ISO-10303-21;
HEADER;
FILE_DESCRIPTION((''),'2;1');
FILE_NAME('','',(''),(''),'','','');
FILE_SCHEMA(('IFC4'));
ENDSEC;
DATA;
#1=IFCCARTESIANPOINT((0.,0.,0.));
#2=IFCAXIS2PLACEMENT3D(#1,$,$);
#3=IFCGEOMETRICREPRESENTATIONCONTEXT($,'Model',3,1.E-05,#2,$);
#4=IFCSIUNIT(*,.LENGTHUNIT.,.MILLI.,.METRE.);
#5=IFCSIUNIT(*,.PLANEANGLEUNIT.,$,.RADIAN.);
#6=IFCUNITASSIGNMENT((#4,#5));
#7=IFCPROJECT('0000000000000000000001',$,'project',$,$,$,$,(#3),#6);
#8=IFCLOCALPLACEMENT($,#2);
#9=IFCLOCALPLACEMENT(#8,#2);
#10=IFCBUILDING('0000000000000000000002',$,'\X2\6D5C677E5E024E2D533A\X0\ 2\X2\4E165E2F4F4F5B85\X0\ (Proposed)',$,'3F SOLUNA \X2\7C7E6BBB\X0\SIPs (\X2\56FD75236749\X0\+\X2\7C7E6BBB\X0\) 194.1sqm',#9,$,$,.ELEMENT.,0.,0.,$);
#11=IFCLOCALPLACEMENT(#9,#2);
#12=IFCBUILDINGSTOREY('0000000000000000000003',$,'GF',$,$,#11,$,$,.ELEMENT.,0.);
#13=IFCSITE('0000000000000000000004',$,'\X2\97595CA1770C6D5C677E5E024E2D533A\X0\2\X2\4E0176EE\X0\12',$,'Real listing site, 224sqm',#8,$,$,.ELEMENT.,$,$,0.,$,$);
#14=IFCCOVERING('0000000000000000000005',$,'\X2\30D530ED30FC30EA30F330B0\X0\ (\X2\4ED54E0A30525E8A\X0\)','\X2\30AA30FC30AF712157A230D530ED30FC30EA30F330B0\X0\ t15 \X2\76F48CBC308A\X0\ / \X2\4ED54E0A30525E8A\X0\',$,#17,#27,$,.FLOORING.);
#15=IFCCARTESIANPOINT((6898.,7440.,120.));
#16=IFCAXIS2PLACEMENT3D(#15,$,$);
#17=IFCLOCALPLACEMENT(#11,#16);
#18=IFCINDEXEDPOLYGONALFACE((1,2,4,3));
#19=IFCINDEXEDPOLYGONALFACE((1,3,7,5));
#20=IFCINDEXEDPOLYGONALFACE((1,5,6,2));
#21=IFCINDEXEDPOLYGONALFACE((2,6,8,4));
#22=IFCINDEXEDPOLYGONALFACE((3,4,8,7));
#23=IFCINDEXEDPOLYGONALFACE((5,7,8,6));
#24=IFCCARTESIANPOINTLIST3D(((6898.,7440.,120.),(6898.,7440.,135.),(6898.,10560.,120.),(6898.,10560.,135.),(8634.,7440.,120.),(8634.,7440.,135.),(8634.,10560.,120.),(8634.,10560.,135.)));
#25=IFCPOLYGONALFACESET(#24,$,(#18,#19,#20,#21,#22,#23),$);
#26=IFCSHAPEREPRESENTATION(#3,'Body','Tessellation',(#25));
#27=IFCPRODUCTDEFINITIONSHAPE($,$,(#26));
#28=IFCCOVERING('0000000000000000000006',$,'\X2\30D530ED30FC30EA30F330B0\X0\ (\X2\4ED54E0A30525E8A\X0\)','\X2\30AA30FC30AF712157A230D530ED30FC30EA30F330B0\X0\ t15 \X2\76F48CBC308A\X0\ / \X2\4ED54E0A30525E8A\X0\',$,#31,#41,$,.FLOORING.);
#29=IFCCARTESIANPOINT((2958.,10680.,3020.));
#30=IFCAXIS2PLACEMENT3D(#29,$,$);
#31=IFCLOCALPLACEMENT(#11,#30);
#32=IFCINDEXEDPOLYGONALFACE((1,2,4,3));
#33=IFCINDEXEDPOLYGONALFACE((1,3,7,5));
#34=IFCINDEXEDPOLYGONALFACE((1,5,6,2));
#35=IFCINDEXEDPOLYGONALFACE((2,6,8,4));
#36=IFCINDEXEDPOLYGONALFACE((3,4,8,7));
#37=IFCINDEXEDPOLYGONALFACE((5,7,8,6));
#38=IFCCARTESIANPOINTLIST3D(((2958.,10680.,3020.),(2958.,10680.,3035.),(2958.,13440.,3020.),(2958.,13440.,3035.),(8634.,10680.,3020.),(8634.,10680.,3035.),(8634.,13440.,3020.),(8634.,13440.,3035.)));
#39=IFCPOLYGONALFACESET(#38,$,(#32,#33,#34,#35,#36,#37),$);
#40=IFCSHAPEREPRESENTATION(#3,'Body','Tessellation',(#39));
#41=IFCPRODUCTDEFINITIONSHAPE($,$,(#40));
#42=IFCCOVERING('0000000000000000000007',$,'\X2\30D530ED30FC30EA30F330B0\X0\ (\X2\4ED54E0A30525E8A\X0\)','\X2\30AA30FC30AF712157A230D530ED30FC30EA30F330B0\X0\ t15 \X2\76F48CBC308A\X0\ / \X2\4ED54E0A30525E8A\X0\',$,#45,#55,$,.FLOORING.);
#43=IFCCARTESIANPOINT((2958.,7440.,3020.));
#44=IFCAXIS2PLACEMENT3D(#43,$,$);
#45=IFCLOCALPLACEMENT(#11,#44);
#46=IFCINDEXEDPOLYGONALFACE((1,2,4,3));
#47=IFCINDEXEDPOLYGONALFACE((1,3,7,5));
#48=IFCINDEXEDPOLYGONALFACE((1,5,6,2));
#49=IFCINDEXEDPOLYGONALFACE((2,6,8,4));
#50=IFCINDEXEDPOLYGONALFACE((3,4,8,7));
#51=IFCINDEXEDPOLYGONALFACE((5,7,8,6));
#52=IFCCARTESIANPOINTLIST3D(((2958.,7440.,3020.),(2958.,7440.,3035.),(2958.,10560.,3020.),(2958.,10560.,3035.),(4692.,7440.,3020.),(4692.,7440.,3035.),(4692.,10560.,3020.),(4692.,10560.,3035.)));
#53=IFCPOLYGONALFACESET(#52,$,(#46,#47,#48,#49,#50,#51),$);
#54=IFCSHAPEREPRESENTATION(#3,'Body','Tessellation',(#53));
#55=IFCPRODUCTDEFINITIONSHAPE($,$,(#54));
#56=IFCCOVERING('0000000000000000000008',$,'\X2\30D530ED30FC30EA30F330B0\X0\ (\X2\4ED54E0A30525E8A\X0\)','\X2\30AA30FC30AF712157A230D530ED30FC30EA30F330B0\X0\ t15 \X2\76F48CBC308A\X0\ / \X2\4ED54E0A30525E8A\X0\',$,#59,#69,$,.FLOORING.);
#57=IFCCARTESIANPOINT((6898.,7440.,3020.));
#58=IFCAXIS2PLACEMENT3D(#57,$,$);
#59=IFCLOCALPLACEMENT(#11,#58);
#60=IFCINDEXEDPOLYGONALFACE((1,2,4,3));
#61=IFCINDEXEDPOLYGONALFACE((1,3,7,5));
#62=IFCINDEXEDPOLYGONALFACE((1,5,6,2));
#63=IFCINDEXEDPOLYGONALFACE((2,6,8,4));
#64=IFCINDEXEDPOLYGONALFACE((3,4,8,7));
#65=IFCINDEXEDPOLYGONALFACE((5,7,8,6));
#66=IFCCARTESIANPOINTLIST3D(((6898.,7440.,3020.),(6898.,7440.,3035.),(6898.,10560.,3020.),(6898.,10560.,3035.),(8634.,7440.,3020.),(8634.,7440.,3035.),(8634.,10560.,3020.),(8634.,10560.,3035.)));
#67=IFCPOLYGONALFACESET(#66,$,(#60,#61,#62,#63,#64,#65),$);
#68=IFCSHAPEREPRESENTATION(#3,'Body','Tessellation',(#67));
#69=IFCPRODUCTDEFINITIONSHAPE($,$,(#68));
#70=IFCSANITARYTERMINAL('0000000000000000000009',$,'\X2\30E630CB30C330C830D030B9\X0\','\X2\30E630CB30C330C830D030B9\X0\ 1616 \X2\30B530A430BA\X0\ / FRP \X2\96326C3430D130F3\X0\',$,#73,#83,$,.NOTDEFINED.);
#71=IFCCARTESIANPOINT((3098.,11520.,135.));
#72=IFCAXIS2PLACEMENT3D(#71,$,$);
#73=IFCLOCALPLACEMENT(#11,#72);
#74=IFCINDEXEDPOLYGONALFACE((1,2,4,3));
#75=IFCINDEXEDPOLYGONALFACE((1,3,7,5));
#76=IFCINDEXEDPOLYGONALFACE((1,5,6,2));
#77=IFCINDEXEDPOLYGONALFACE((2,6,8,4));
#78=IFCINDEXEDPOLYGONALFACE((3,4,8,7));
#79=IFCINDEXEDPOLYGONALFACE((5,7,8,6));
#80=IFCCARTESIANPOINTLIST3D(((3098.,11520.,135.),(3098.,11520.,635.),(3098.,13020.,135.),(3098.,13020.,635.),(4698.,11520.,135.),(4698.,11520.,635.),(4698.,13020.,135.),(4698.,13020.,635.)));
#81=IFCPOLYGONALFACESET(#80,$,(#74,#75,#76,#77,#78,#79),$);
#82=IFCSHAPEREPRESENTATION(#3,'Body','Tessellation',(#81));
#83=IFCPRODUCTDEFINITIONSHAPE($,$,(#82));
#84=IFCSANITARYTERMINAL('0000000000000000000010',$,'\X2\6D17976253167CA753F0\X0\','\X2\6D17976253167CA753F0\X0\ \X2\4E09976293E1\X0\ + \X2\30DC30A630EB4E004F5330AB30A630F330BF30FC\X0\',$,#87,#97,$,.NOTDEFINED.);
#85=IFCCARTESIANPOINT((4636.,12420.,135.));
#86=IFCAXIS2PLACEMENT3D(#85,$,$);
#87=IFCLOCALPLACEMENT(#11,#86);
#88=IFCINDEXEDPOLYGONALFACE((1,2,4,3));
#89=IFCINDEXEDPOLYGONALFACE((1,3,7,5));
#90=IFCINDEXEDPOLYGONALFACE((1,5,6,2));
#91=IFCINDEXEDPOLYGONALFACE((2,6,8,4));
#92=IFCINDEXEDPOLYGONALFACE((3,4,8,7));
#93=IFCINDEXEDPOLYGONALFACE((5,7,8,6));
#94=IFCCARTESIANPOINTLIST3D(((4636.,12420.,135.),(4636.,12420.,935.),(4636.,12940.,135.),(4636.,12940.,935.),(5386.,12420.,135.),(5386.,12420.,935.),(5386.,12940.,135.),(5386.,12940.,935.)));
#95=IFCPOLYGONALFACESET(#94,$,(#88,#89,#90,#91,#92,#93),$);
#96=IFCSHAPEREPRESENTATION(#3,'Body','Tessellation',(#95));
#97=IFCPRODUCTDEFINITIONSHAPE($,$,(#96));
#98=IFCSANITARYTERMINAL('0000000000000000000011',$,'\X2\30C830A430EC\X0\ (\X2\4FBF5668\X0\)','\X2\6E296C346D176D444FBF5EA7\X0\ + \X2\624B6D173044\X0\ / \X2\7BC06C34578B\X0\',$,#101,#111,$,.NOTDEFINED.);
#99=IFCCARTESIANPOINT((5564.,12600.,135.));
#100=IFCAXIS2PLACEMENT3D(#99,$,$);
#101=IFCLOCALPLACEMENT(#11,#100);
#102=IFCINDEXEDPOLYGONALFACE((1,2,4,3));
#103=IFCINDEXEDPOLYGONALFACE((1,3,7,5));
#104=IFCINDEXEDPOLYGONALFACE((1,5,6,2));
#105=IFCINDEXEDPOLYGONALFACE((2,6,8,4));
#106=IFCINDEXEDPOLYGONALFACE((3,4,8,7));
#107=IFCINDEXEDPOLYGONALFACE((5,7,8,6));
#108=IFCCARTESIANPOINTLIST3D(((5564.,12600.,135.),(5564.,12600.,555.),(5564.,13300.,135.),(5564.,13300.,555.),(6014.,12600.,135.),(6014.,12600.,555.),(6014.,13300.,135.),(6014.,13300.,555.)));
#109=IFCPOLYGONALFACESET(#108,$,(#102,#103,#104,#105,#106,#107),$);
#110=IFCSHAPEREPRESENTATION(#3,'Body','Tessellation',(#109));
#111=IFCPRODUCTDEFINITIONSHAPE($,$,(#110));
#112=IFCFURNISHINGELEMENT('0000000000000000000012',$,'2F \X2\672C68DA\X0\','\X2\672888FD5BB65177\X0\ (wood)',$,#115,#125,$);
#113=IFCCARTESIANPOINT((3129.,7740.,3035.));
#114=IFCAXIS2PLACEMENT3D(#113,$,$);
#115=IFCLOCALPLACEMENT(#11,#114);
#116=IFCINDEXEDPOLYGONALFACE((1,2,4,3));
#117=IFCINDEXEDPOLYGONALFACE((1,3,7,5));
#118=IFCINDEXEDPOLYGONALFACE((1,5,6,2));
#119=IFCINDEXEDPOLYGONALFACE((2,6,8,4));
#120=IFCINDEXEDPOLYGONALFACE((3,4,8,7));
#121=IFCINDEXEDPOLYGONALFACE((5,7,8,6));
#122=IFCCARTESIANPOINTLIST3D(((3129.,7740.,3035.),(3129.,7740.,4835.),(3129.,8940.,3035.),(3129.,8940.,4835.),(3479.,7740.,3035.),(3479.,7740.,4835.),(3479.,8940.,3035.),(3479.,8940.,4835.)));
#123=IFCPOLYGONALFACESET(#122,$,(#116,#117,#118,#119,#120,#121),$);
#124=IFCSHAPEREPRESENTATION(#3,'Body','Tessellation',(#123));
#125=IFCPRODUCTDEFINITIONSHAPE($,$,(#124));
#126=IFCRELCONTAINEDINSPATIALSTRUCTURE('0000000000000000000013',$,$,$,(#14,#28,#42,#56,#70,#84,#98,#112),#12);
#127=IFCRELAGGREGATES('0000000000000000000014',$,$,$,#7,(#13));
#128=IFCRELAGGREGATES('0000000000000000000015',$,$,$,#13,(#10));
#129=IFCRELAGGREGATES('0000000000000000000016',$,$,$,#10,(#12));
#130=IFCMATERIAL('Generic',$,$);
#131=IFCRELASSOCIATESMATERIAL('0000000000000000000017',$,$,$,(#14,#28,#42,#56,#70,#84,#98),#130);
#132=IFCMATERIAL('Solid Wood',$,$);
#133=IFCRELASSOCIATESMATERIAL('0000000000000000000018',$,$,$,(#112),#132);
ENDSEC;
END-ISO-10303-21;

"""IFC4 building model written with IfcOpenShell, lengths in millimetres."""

from ifc_helpers import new_model, si_unit, frame, frame_2d, origin, place, context, project, spatial, rectangle, extrude, material, element, save


model = new_model("IFC4")

# Units and contexts
model_context = context("Model", 3, precision=1e-05, world=origin())
ifc_project = project(units=[si_unit("LENGTHUNIT", "METRE", prefix="MILLI"), si_unit("PLANEANGLEUNIT", "RADIAN")], contexts=[model_context])

# Site, building, storey
site_placement = place(None, origin())
site = spatial("IfcSite", under=ifc_project, at=site_placement, Name="静岡県浜松市中区2丁目12", ObjectType="Real listing site, 224sqm", CompositionType="ELEMENT", RefElevation=0.0)
building_placement = place(site_placement, origin())
building = spatial("IfcBuilding", under=site, at=building_placement, Name="浜松市中区 2世帯住宅 (Proposed)", ObjectType="3F SOLUNA 籾殻SIPs (国産杉+籾殻) 194.1sqm", CompositionType="ELEMENT", ElevationOfRefHeight=0.0, ElevationOfTerrain=0.0)
storey_placement = place(building_placement, origin())
storey = spatial("IfcBuildingStorey", under=building, at=storey_placement, Name="GF", CompositionType="ELEMENT", Elevation=0.0)

# Shared definitions
ifc_material_1 = material(Name="Solid Wood")

# Coverings
ifc_material_2 = material(Name="Generic")
covering_1_placement = place(storey_placement, frame((6898.0, 7440.0, 120.0)))
element("IfcCovering", 1, at=covering_1_placement, inside=storey, material=ifc_material_2, Name="フローリング (仕上げ床)", Description="オーク無垢フローリング t15 直貼り / 仕上げ床", PredefinedType="FLOORING", context=model_context, shape_type="SweptSolid", body=[
    extrude(rectangle(XDim=1736.0, YDim=3120.0, at=frame_2d((868.0, 1560.0))), frame((6898.0, 7440.0, 120.0)), (0.0, 0.0, 1.0), 15.0),
])
covering_2_placement = place(storey_placement, frame((2958.0, 10680.0, 3020.0)))
element("IfcCovering", 2, at=covering_2_placement, inside=storey, material=ifc_material_2, Name="フローリング (仕上げ床)", Description="オーク無垢フローリング t15 直貼り / 仕上げ床", PredefinedType="FLOORING", context=model_context, shape_type="SweptSolid", body=[
    extrude(rectangle(XDim=5676.0, YDim=2760.0, at=frame_2d((2838.0, 1380.0))), frame((2958.0, 10680.0, 3020.0)), (0.0, 0.0, 1.0), 15.0),
])
covering_3_placement = place(storey_placement, frame((2958.0, 7440.0, 3020.0)))
element("IfcCovering", 3, at=covering_3_placement, inside=storey, material=ifc_material_2, Name="フローリング (仕上げ床)", Description="オーク無垢フローリング t15 直貼り / 仕上げ床", PredefinedType="FLOORING", context=model_context, shape_type="SweptSolid", body=[
    extrude(rectangle(XDim=1734.0, YDim=3120.0, at=frame_2d((867.0, 1560.0))), frame((2958.0, 7440.0, 3020.0)), (0.0, 0.0, 1.0), 15.0),
])
covering_4_placement = place(storey_placement, frame((6898.0, 7440.0, 3020.0)))
element("IfcCovering", 4, at=covering_4_placement, inside=storey, material=ifc_material_2, Name="フローリング (仕上げ床)", Description="オーク無垢フローリング t15 直貼り / 仕上げ床", PredefinedType="FLOORING", context=model_context, shape_type="SweptSolid", body=[
    extrude(rectangle(XDim=1736.0, YDim=3120.0, at=frame_2d((868.0, 1560.0))), frame((6898.0, 7440.0, 3020.0)), (0.0, 0.0, 1.0), 15.0),
])

# Sanitary terminals
sanitary_terminal_1_placement = place(storey_placement, frame((3098.0, 11520.0, 135.0)))
element("IfcSanitaryTerminal", 5, at=sanitary_terminal_1_placement, inside=storey, material=ifc_material_2, Name="ユニットバス", Description="ユニットバス 1616 サイズ / FRP 防水パン", PredefinedType="NOTDEFINED", context=model_context, shape_type="SweptSolid", body=[
    extrude(rectangle(XDim=1600.0, YDim=1500.0, at=frame_2d((800.0, 750.0))), frame((3098.0, 11520.0, 135.0)), (0.0, 0.0, 1.0), 500.0),
])
sanitary_terminal_2_placement = place(storey_placement, frame((4636.0, 12420.0, 135.0)))
element("IfcSanitaryTerminal", 6, at=sanitary_terminal_2_placement, inside=storey, material=ifc_material_2, Name="洗面化粧台", Description="洗面化粧台 三面鏡 + ボウル一体カウンター", PredefinedType="NOTDEFINED", context=model_context, shape_type="SweptSolid", body=[
    extrude(rectangle(XDim=750.0, YDim=520.0, at=frame_2d((375.0, 260.0))), frame((4636.0, 12420.0, 135.0)), (0.0, 0.0, 1.0), 800.0),
])
sanitary_terminal_3_placement = place(storey_placement, frame((5564.0, 12600.0, 135.0)))
element("IfcSanitaryTerminal", 7, at=sanitary_terminal_3_placement, inside=storey, material=ifc_material_2, Name="トイレ (便器)", Description="温水洗浄便座 + 手洗い / 節水型", PredefinedType="NOTDEFINED", context=model_context, shape_type="SweptSolid", body=[
    extrude(rectangle(XDim=450.0, YDim=700.0, at=frame_2d((225.0, 350.0))), frame((5564.0, 12600.0, 135.0)), (0.0, 0.0, 1.0), 420.0),
])

# Furnishing element
furnishing_placement = place(storey_placement, frame((3129.0, 7740.0, 3035.0)))
element("IfcFurnishingElement", 8, at=furnishing_placement, inside=storey, material=ifc_material_1, Name="2F 本棚", Description="木製家具 (wood)", context=model_context, shape_type="SweptSolid", body=[
    extrude(rectangle(XDim=350.0, YDim=1200.0, at=frame_2d((175.0, 600.0))), frame((3129.0, 7740.0, 3035.0)), (0.0, 0.0, 1.0), 1800.0),
])

save(model, "model.ifc")
